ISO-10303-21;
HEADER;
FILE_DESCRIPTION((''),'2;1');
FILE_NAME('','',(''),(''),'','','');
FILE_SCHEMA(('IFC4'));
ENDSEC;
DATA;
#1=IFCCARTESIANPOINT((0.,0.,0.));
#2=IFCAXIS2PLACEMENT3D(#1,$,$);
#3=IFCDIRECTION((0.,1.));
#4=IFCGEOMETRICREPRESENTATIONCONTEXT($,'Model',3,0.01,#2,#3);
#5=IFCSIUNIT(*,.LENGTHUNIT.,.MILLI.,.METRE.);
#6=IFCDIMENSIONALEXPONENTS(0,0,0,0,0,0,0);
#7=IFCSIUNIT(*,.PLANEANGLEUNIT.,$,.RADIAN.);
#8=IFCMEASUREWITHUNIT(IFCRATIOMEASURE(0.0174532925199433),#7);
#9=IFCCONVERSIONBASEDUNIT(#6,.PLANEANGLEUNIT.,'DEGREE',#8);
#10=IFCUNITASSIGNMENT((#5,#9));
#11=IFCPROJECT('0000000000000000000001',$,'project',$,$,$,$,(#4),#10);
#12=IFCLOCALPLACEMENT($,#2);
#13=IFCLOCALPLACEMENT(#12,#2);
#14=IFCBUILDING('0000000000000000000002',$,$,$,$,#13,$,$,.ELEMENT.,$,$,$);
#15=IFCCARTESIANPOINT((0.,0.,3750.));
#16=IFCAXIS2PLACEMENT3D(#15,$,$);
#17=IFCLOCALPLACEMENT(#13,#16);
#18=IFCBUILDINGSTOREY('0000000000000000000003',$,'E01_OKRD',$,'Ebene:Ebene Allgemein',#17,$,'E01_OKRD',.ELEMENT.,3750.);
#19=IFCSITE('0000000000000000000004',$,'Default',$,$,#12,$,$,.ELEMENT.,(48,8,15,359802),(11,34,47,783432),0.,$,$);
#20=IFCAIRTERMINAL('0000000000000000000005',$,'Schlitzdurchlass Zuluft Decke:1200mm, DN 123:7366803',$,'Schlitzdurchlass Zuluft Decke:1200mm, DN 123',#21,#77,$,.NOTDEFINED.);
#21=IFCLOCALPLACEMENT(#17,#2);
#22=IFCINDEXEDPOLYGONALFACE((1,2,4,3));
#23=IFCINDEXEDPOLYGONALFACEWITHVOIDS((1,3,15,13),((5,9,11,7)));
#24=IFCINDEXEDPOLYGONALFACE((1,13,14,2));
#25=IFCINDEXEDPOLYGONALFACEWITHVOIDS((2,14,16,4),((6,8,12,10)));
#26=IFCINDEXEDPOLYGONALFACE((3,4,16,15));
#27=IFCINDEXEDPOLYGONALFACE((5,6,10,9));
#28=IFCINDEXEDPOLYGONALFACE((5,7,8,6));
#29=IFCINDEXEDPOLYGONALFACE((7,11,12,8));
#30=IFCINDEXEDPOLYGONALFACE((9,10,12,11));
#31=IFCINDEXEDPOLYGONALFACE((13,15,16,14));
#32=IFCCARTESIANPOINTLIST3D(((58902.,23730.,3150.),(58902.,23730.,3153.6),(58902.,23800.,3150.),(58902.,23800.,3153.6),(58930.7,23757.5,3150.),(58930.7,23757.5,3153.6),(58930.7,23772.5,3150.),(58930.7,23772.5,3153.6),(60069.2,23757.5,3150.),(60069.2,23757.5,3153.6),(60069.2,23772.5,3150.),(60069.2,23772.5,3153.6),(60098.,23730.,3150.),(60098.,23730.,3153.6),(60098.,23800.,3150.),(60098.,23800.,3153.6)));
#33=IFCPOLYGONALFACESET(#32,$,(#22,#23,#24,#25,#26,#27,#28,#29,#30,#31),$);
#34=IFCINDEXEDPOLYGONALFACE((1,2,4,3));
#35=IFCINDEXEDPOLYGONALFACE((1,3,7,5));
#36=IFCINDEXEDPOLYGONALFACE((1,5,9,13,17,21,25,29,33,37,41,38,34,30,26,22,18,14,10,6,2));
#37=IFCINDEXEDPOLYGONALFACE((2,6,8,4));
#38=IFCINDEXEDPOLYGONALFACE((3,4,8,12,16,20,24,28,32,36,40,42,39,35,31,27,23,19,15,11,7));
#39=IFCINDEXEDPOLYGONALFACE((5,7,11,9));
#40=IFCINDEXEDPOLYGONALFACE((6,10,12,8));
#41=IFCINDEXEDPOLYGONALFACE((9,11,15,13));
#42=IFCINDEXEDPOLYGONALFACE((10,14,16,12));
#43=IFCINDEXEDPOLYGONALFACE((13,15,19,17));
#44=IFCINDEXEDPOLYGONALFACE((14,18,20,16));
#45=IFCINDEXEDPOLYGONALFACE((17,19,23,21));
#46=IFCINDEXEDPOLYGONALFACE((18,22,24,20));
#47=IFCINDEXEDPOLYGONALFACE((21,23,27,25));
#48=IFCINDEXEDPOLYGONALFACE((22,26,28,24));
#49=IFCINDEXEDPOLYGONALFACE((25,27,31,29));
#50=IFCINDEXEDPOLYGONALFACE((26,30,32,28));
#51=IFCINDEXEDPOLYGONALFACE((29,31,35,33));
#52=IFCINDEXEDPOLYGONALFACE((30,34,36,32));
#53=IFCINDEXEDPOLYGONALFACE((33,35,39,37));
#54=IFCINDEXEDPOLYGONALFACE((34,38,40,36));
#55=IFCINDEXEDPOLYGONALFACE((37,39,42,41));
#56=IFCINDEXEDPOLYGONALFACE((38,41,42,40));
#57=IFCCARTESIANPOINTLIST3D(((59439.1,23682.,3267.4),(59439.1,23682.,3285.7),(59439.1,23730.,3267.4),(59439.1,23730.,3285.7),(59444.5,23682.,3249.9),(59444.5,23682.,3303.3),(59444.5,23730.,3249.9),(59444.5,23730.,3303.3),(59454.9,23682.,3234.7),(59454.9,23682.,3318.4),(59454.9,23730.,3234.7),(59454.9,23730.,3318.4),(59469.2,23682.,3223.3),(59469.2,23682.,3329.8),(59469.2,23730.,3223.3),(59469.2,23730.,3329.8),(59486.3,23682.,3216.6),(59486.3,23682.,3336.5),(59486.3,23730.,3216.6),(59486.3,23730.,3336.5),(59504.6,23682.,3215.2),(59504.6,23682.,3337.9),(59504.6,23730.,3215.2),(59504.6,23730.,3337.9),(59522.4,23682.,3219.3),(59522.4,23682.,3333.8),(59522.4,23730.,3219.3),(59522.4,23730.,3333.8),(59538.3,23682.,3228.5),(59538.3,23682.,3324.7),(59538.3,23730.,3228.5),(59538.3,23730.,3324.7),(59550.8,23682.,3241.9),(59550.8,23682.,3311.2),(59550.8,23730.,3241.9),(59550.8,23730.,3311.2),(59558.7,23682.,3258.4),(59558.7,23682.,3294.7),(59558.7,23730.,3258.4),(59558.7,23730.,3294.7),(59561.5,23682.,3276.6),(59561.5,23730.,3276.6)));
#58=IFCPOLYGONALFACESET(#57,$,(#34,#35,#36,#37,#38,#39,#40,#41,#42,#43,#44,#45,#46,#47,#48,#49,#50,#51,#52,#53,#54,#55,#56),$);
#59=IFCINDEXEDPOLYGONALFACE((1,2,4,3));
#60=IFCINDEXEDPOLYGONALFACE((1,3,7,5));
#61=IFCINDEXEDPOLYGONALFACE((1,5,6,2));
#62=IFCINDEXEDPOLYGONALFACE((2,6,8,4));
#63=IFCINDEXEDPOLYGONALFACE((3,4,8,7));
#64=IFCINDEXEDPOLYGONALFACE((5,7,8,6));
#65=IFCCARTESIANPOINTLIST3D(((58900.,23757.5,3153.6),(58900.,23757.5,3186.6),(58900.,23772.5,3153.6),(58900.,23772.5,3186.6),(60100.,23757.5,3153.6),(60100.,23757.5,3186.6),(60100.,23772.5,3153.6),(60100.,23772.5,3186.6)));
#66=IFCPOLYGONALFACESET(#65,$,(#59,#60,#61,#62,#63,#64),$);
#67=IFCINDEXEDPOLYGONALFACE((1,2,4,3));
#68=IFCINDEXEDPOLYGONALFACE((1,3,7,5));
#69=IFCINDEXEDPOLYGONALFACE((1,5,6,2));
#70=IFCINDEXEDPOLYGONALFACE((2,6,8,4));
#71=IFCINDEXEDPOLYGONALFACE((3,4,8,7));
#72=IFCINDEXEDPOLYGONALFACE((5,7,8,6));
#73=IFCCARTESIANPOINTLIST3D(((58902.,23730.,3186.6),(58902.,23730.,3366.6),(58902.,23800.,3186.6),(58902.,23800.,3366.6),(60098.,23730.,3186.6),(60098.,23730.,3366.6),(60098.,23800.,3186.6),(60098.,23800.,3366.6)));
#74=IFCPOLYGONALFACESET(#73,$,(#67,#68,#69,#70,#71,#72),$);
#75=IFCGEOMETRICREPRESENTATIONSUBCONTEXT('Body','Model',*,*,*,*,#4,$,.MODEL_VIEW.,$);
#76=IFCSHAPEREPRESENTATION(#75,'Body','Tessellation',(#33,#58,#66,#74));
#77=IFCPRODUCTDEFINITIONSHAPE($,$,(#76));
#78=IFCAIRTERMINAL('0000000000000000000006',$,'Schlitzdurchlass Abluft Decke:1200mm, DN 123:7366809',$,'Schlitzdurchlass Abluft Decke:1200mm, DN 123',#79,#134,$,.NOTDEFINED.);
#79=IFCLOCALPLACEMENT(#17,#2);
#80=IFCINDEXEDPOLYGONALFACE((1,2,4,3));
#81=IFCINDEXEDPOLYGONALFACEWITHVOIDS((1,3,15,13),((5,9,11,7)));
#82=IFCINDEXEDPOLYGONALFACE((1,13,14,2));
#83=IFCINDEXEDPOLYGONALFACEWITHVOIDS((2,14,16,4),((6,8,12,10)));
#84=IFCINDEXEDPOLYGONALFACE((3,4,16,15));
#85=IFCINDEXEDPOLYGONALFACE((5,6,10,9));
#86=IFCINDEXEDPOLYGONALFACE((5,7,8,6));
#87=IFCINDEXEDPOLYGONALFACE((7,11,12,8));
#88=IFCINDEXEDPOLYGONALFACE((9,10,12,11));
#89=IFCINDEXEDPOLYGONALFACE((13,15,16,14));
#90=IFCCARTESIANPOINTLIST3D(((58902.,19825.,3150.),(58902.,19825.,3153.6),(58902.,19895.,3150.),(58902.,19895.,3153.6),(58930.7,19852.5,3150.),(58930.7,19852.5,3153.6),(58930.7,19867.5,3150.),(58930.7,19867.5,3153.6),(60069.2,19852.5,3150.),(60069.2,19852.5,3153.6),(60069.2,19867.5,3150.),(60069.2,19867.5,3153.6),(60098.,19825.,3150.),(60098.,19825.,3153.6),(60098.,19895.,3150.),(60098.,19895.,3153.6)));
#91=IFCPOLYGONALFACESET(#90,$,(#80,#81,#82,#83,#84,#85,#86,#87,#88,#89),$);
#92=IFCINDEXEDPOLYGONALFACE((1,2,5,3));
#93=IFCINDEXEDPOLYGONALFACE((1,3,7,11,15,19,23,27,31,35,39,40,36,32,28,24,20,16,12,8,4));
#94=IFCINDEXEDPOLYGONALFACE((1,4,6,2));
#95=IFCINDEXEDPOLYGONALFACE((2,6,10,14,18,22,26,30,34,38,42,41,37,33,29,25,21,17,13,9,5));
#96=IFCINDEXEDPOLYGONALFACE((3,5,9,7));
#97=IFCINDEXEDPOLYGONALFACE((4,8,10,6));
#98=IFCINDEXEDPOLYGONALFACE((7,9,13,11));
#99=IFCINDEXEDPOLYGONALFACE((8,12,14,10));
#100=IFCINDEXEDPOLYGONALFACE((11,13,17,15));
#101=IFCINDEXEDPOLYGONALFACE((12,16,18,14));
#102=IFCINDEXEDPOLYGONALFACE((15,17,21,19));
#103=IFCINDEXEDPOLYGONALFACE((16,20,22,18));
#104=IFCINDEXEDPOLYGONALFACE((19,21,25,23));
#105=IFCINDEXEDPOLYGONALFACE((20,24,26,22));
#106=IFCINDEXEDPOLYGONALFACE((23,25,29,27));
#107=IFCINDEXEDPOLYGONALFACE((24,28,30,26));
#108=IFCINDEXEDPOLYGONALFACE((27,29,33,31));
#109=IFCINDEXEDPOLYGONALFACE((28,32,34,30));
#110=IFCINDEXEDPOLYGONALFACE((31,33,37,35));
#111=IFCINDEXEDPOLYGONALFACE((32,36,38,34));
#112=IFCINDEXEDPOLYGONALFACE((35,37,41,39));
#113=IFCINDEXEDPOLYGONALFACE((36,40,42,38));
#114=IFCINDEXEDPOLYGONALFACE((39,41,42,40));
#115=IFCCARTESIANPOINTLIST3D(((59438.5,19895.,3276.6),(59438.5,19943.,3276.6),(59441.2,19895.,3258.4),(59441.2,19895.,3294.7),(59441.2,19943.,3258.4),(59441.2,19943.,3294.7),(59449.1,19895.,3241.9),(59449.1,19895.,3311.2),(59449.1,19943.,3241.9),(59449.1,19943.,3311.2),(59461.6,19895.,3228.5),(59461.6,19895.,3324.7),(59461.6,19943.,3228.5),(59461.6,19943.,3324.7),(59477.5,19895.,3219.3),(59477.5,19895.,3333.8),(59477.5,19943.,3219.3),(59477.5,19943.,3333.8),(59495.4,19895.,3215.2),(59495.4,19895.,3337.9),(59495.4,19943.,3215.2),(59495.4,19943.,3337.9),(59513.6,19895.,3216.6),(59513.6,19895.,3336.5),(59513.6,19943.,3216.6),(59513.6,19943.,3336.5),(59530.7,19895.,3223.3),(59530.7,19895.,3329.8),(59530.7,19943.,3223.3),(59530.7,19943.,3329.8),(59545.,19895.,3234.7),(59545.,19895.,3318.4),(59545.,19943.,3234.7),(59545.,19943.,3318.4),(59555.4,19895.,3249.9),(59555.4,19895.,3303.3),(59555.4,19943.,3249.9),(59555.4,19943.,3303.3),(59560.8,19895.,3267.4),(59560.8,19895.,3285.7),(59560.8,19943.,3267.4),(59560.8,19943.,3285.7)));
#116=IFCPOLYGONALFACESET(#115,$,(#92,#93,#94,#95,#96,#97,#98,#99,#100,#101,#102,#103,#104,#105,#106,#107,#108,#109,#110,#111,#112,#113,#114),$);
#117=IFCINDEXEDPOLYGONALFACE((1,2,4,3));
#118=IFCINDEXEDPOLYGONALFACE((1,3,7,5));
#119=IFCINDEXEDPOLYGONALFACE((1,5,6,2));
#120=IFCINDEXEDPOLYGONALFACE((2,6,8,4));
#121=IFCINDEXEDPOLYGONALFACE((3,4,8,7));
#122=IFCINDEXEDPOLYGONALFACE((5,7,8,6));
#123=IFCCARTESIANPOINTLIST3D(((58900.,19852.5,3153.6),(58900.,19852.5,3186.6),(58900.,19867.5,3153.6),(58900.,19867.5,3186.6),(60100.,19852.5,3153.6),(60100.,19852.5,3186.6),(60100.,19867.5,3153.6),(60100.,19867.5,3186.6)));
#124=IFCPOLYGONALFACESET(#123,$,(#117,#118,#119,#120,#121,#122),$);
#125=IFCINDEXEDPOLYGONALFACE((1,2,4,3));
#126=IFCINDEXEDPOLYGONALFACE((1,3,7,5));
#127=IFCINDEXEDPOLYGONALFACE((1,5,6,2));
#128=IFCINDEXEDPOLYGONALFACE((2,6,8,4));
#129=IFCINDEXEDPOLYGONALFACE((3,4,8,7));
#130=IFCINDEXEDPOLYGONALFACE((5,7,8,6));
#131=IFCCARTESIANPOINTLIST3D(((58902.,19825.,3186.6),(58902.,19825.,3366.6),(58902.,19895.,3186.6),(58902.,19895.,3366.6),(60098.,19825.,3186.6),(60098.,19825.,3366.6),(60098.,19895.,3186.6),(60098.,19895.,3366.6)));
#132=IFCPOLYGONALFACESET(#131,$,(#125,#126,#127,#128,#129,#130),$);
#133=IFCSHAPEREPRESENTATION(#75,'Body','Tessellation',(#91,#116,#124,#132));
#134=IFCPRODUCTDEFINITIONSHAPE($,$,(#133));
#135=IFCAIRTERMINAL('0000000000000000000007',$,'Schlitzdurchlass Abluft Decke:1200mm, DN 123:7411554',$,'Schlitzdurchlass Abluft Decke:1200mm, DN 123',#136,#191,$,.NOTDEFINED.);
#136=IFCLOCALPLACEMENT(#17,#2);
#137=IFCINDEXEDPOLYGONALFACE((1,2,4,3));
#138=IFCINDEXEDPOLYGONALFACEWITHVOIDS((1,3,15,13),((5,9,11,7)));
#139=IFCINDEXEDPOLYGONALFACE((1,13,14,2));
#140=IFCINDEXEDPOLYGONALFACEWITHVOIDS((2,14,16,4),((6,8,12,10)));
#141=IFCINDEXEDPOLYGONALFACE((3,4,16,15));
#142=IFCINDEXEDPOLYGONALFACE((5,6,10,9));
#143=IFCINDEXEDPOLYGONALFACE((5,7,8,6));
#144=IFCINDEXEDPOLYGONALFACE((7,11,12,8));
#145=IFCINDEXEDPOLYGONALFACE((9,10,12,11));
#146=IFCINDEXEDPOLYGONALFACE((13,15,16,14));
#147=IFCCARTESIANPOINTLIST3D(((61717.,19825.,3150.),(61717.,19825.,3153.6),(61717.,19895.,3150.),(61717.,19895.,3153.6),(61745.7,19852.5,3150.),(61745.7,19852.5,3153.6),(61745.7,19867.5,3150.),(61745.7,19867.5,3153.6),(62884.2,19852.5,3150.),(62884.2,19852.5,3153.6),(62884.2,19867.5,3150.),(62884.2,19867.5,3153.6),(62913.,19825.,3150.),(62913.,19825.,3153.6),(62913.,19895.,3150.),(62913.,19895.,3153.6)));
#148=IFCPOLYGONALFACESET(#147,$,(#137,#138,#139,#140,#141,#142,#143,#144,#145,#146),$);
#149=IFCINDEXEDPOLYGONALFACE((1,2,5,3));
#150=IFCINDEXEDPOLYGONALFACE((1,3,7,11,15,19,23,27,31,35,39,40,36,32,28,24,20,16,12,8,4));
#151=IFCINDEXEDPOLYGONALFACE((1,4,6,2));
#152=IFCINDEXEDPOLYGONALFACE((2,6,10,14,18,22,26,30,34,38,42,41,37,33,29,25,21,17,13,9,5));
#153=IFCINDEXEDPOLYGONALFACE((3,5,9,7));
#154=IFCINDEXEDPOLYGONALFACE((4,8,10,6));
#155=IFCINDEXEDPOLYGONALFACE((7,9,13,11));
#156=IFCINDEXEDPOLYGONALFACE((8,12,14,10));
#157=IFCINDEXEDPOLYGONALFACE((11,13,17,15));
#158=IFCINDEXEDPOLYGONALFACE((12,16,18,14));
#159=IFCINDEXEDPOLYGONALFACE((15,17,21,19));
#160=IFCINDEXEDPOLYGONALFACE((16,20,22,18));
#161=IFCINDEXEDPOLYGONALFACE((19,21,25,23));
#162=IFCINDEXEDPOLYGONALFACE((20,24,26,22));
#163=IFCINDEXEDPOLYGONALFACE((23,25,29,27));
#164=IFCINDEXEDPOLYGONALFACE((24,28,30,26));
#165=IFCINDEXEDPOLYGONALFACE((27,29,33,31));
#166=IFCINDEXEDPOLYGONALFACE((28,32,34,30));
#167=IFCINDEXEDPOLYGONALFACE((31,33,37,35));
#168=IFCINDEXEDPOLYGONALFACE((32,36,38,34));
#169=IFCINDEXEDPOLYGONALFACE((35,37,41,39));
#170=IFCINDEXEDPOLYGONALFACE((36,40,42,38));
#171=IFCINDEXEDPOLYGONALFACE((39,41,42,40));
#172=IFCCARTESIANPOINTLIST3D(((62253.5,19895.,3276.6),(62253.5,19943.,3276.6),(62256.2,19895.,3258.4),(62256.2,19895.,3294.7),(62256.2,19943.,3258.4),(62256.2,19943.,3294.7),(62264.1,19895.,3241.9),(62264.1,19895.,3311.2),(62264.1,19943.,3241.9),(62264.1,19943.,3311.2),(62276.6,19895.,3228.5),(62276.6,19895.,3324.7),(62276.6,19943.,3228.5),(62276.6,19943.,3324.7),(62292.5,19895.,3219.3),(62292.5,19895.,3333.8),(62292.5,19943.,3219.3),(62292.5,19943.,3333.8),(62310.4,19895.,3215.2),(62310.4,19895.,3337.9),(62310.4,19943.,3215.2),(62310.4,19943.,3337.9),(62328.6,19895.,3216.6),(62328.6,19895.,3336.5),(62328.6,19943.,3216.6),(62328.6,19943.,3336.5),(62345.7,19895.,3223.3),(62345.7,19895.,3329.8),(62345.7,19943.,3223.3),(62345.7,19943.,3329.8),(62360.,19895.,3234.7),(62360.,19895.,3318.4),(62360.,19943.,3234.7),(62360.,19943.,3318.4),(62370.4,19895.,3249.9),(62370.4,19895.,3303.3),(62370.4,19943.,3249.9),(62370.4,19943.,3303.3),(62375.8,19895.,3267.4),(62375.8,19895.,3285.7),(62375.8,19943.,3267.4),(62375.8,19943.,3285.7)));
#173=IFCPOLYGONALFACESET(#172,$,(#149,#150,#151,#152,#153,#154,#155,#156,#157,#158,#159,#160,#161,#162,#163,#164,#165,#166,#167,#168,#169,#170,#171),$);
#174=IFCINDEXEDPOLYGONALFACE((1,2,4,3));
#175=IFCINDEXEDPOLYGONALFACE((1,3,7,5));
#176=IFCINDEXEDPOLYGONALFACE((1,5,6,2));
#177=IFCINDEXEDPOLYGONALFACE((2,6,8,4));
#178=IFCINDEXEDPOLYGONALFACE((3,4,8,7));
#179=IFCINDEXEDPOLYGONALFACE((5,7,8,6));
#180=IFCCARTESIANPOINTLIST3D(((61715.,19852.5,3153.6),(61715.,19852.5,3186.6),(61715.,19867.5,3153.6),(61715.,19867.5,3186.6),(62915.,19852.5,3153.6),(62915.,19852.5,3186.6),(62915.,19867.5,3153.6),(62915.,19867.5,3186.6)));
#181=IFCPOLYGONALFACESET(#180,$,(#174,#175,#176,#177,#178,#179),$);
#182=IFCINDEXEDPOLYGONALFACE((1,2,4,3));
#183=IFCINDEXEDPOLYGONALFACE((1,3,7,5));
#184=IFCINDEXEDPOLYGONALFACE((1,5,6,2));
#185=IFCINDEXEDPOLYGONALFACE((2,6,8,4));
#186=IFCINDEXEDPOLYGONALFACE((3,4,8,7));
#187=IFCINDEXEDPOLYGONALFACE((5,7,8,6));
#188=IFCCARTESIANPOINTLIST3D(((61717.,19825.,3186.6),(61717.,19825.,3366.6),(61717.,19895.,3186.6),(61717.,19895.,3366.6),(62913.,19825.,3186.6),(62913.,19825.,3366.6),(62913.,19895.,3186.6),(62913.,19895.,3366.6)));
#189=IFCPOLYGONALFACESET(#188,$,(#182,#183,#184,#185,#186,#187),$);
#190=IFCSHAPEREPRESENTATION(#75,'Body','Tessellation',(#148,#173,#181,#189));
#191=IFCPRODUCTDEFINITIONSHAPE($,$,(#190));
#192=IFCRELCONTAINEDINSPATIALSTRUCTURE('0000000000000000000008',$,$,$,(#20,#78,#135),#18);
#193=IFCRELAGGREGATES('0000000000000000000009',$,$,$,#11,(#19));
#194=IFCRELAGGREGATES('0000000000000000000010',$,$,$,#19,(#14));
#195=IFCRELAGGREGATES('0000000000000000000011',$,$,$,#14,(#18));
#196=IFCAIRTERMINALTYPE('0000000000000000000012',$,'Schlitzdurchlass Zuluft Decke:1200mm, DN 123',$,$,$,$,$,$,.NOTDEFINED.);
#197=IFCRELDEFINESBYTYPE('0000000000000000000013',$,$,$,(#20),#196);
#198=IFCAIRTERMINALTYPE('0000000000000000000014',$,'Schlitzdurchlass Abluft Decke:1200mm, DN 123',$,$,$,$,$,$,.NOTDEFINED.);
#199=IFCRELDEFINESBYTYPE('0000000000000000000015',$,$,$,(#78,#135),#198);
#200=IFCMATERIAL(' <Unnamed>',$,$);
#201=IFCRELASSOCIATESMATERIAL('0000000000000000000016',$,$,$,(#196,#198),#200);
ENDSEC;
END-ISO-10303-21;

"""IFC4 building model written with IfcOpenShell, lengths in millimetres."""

from ifc_helpers import new_model, entity, si_unit, converted_unit, direction, frame, frame_2d, origin, origin_2d_with_axis, place, context, subcontext, project, spatial, polyline, rectangle, circle, outline, extrude, source, transform, mapped, material, type_object, type_shapes, element, save


model = new_model("IFC4")

# Units and contexts
model_context = context("Model", 3, precision=0.01, world=origin(), true_north=direction((0.0, 1.0)))
body_context = subcontext(model_context, "Body", "Model", "MODEL_VIEW")
ifc_project = project(units=[si_unit("LENGTHUNIT", "METRE", prefix="MILLI"), converted_unit("PLANEANGLEUNIT", "DEGREE", entity("IfcRatioMeasure", 0.0174532925199433), si_unit("PLANEANGLEUNIT", "RADIAN"), dimensions=[0, 0, 0, 0, 0, 0, 0])], contexts=[model_context])

# Site, building, storey
site_placement = place(None, origin())
site = spatial("IfcSite", under=ifc_project, at=site_placement, Name="Default", CompositionType="ELEMENT", RefLatitude=(48, 8, 15, 359802), RefLongitude=(11, 34, 47, 783432), RefElevation=0.0)
building_placement = place(site_placement, origin())
building = spatial("IfcBuilding", under=site, at=building_placement, CompositionType="ELEMENT")
storey_placement = place(building_placement, frame((0.0, 0.0, 3750.0)))
storey = spatial("IfcBuildingStorey", under=building, at=storey_placement, Name="E01_OKRD", ObjectType="Ebene:Ebene Allgemein", LongName="E01_OKRD", CompositionType="ELEMENT", Elevation=3750.0)

# Air terminals
ifc_material_1 = material(Name=" <Unnamed>")
air_terminal_type_1 = type_object("IfcAirTerminalType", Name="Schlitzdurchlass Zuluft Decke:1200mm, DN 123", PredefinedType="NOTDEFINED", material=ifc_material_1)
shared_shape_1 = source(origin(), body_context, "Body", "SweptSolid", [
    extrude(outline(polyline([(-598.0, -35.0), (598.0, -35.0), (598.0, 35.0), (-598.0, 35.0), (-598.0, -35.0)]), holes=[polyline([(-569.2, -7.5), (-569.2, 7.5), (569.2, 7.5), (569.2, -7.5), (-569.2, -7.5)])]), frame((600.0, 35.0, 0.0), z_axis=(0.0, 0.0, 1.0), x_axis=(-1.0, 0.0, 0.0)), (0.0, 0.0, 1.0), 3.6),
    extrude(circle(Radius=61.5, at=frame_2d((0.0, 0.0), x_axis=(1.0, 0.0))), frame((600.0, 70.0, 126.6), z_axis=(0.0, 1.0, 0.0), x_axis=(-1.0, 0.0, 0.0)), (0.0, 0.0, 1.0), 48.0),
    extrude(rectangle(XDim=1200.0, YDim=15.0, at=origin_2d_with_axis()), frame((600.0, 35.0, 3.6), z_axis=(0.0, 0.0, 1.0), x_axis=(-1.0, 0.0, 0.0)), (0.0, 0.0, 1.0), 33.0),
    extrude(rectangle(XDim=1196.0, YDim=70.0, at=origin_2d_with_axis()), frame((600.0, 35.0, 36.6), z_axis=(0.0, 0.0, 1.0), x_axis=(-1.0, 0.0, 0.0)), (0.0, 0.0, 1.0), 180.0),
])
type_shapes(air_terminal_type_1, [shared_shape_1])
air_terminal_placement = place(storey_placement, frame((60100.0, 23800.0, 3150.0), z_axis=(0.0, 0.0, 1.0), x_axis=(-1.0, 0.0, 0.0)))
element("IfcAirTerminal", 1, at=air_terminal_placement, inside=storey, type_object=air_terminal_type_1, Name="Schlitzdurchlass Zuluft Decke:1200mm, DN 123:7366803", ObjectType="Schlitzdurchlass Zuluft Decke:1200mm, DN 123", PredefinedType="NOTDEFINED", context=body_context, shape_type="MappedRepresentation", body=[
    mapped(shared_shape_1, transform((0.0, 0.0, 0.0), scale=1.0)),
])
air_terminal_type_2 = type_object("IfcAirTerminalType", Name="Schlitzdurchlass Abluft Decke:1200mm, DN 123", PredefinedType="NOTDEFINED", material=ifc_material_1)
shared_shape_2 = source(origin(), body_context, "Body", "SweptSolid", [
    extrude(outline(polyline([(-598.0, -35.0), (598.0, -35.0), (598.0, 35.0), (-598.0, 35.0), (-598.0, -35.0)]), holes=[polyline([(-569.2, -7.5), (-569.2, 7.5), (569.2, 7.5), (569.2, -7.5), (-569.2, -7.5)])]), frame((0.0, 0.0, 0.0), z_axis=(0.0, 0.0, 1.0), x_axis=(-1.0, 0.0, 0.0)), (0.0, 0.0, 1.0), 3.6),
    extrude(circle(Radius=61.5, at=frame_2d((0.0, 0.0), x_axis=(1.0, 0.0))), frame((0.0, 35.0, 126.6), z_axis=(0.0, 1.0, 0.0), x_axis=(-1.0, 0.0, 0.0)), (0.0, 0.0, 1.0), 48.0),
    extrude(rectangle(XDim=1200.0, YDim=15.0, at=origin_2d_with_axis()), frame((0.0, 0.0, 3.6), z_axis=(0.0, 0.0, 1.0), x_axis=(-1.0, 0.0, 0.0)), (0.0, 0.0, 1.0), 33.0),
    extrude(rectangle(XDim=1196.0, YDim=70.0, at=origin_2d_with_axis()), frame((0.0, 0.0, 36.6), z_axis=(0.0, 0.0, 1.0), x_axis=(-1.0, 0.0, 0.0)), (0.0, 0.0, 1.0), 180.0),
])
type_shapes(air_terminal_type_2, [shared_shape_2])
for number, where, name in (
    (2, (59500.0, 19860.0, 3150.0), "Schlitzdurchlass Abluft Decke:1200mm, DN 123:7366809"),
    (3, (62315.0, 19860.0, 3150.0), "Schlitzdurchlass Abluft Decke:1200mm, DN 123:7411554"),
):
    element("IfcAirTerminal", number, at=place(storey_placement, frame(where)), inside=storey, type_object=air_terminal_type_2, Name=name, ObjectType="Schlitzdurchlass Abluft Decke:1200mm, DN 123", PredefinedType="NOTDEFINED", context=body_context, shape_type="MappedRepresentation", body=[
        mapped(shared_shape_2, transform((0.0, 0.0, 0.0), scale=1.0)),
    ])

save(model, "model.ifc")
